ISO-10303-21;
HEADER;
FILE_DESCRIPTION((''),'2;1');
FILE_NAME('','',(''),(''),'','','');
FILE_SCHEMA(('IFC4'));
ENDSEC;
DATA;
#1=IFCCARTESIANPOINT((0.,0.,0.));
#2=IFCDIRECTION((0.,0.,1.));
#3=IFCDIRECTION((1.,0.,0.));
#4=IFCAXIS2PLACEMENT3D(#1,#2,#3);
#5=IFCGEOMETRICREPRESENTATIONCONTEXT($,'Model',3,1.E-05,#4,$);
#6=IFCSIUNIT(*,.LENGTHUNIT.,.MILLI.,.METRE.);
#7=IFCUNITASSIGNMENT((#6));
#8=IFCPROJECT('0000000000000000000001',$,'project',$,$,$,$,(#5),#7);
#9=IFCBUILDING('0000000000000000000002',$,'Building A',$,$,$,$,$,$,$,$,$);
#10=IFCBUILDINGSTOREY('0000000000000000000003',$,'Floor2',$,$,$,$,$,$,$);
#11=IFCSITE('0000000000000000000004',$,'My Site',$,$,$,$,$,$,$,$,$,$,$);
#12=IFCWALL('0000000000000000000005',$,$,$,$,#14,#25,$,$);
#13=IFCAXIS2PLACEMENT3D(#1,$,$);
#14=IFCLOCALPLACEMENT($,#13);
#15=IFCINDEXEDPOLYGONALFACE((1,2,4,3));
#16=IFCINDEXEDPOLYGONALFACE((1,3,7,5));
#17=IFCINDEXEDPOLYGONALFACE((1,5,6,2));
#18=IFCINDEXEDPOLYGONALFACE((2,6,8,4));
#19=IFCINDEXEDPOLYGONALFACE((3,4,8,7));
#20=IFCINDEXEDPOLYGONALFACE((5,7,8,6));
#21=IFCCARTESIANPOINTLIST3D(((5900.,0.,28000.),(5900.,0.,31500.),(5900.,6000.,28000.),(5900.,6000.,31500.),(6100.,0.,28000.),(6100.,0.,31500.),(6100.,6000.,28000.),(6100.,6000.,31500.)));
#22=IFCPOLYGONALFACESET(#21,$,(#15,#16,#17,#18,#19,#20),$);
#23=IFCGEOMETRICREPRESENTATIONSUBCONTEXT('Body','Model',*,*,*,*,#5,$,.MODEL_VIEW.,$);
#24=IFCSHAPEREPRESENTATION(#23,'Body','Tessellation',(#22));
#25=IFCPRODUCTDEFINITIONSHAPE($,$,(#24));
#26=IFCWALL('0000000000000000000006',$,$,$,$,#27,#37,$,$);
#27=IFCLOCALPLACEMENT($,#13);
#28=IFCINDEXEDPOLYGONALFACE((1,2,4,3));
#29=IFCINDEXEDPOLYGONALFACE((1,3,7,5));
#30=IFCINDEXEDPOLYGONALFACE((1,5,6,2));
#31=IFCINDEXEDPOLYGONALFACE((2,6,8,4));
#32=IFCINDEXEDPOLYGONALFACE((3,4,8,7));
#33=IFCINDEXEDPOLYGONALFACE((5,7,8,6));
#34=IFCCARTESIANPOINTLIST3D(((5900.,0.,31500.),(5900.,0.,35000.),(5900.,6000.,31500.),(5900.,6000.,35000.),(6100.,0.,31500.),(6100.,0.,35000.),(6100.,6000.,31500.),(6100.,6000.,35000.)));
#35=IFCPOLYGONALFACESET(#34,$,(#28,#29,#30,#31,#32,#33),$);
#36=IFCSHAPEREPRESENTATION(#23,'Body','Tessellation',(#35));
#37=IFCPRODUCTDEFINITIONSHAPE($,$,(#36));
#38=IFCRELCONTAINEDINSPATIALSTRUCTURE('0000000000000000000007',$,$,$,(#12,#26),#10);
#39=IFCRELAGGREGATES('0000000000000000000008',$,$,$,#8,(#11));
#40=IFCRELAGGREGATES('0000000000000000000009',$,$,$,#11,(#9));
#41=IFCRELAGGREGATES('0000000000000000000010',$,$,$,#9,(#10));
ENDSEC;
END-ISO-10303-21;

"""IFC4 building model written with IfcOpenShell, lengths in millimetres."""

from ifc_helpers import new_model, si_unit, frame, origin_with_axes, place, context, subcontext, project, spatial, indexed_curve, outline, extrude, element, save


model = new_model("IFC4")

# Units and contexts
model_context = context("Model", 3, precision=1e-05, world=origin_with_axes())
body_context = subcontext(model_context, "Body", "Model", "MODEL_VIEW")
ifc_project = project(units=[si_unit("LENGTHUNIT", "METRE", prefix="MILLI")], contexts=[model_context])

# Site, building, storey
site = spatial("IfcSite", under=ifc_project, Name="My Site")
building = spatial("IfcBuilding", under=site, Name="Building A")
storey = spatial("IfcBuildingStorey", under=building, Name="Floor2")

# Walls
for number, where, z_axis, x_axis in (
    (1, (6100.0, 0.0, 28000.0), (0.0, 0.0, 1.0), (0.0, 1.0, 0.0)),
    (2, (6100.0, 0.0, 31500.0), (0.0, 0.0, 1.0), (0.0, 1.0, 0.0)),
):
    element("IfcWall", number, at=place(None, frame(where, z_axis=z_axis, x_axis=x_axis)), inside=storey, context=body_context, shape_type="SweptSolid", body=[
        extrude(outline(indexed_curve([(0.0, 0.0), (0.0, 200.0), (6000.0, 200.0), (6000.0, 0.0), (0.0, 0.0)], self_intersect=False)), origin_with_axes(), (0.0, 0.0, 1.0), 3500.0),
    ])

save(model, "model.ifc")
